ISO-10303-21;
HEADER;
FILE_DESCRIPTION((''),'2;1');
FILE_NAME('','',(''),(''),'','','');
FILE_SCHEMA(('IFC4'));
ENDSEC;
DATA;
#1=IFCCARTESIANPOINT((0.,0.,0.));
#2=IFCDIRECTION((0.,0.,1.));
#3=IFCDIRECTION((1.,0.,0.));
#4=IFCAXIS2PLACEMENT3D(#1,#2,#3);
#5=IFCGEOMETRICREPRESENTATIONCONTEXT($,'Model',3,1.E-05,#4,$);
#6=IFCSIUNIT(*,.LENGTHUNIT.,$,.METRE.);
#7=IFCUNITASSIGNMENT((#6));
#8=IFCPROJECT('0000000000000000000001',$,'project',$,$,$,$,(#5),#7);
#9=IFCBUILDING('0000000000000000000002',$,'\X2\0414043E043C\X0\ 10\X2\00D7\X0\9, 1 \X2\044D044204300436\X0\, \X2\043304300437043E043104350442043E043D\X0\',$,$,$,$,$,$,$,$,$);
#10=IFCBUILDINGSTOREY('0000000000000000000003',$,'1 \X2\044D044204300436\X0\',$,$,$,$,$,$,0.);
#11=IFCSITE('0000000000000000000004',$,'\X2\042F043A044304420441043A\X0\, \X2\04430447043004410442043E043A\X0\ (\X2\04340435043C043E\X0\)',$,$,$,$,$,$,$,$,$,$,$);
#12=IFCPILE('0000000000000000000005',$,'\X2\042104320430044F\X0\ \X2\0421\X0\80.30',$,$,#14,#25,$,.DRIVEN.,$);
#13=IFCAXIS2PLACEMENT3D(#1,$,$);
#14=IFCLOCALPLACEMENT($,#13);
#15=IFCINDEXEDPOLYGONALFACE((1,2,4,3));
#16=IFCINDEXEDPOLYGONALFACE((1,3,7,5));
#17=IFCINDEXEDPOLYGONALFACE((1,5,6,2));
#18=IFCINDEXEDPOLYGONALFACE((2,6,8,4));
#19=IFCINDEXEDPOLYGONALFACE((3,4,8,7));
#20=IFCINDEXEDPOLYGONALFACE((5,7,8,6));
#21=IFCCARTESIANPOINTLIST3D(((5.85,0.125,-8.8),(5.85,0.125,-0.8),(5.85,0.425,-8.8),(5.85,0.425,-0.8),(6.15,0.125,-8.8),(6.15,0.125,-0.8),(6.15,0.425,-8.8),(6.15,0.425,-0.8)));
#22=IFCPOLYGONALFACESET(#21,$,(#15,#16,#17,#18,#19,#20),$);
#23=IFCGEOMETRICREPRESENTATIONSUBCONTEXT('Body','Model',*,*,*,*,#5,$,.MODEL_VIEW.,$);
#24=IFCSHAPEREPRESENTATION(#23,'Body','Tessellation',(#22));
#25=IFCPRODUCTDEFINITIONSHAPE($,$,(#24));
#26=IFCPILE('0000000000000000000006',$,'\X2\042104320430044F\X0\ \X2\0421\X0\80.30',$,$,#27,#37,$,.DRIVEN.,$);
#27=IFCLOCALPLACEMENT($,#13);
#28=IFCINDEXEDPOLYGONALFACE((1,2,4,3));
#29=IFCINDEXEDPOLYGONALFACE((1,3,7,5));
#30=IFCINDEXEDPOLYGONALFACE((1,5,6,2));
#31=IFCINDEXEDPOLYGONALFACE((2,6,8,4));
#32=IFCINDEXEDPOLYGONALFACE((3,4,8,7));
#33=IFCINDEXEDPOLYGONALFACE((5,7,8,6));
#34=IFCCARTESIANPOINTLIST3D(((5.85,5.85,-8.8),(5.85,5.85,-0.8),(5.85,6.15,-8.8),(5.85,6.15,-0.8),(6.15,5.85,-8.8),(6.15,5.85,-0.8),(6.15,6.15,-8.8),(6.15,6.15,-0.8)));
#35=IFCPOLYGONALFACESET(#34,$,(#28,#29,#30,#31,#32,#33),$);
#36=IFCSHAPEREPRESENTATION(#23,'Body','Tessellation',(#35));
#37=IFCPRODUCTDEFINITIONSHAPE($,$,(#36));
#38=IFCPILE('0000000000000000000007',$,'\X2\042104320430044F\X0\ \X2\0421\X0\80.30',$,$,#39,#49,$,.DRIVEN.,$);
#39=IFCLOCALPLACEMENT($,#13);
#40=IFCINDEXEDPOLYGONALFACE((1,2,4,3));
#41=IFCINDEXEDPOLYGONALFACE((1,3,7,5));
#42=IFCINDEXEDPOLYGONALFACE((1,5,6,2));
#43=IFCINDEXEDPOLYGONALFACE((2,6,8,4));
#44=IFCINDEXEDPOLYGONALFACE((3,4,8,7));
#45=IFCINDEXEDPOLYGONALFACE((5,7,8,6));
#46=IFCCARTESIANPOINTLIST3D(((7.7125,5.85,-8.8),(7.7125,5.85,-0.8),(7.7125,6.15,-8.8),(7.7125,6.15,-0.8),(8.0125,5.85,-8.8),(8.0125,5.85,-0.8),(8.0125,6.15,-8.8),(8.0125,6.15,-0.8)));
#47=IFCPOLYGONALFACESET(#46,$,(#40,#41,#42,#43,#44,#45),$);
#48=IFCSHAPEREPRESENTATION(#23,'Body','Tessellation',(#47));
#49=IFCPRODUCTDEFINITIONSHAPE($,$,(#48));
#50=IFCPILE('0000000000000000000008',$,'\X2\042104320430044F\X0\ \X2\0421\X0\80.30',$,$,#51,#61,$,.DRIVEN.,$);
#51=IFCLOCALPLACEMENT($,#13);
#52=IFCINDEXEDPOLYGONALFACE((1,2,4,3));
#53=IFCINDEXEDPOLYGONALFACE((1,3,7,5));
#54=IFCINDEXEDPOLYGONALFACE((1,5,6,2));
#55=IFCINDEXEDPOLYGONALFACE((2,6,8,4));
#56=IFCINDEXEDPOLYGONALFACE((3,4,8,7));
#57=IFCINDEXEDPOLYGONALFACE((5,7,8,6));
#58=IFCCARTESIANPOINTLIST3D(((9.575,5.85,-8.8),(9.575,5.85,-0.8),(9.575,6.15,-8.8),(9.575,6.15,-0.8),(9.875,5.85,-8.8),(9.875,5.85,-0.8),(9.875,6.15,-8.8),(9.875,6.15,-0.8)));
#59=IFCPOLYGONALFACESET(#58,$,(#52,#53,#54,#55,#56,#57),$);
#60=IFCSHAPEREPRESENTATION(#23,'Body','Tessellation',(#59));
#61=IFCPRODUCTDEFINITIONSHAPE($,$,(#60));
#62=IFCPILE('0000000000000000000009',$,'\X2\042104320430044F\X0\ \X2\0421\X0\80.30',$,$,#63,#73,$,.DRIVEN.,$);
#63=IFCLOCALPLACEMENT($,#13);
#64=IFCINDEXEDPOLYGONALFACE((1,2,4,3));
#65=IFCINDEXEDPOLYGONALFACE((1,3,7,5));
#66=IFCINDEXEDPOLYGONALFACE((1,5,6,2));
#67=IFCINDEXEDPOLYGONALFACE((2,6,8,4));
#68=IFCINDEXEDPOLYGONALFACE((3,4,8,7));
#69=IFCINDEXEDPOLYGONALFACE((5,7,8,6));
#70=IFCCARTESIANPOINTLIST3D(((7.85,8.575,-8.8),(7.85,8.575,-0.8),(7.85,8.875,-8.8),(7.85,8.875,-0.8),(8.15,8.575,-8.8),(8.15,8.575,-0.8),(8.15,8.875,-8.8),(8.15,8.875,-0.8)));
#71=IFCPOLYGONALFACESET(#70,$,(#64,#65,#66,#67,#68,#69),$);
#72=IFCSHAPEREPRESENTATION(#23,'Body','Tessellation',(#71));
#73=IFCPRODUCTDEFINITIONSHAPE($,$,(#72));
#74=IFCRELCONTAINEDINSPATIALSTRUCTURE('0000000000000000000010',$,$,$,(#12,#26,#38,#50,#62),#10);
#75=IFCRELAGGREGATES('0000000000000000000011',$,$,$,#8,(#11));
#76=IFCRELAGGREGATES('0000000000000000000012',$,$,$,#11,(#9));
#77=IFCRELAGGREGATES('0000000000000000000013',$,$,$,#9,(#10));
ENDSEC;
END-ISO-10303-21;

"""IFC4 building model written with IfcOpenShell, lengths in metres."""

from ifc_helpers import new_model, si_unit, frame, origin_with_axes, place, context, subcontext, project, spatial, rectangle, extrude, element, save


model = new_model("IFC4")

# Units and contexts
model_context = context("Model", 3, precision=1e-05, world=origin_with_axes())
body_context = subcontext(model_context, "Body", "Model", "MODEL_VIEW")
ifc_project = project(units=[si_unit("LENGTHUNIT", "METRE")], contexts=[model_context])

# Site, building, storey
site = spatial("IfcSite", under=ifc_project, Name="Якутск, участок (демо)")
building = spatial("IfcBuilding", under=site, Name="Дом 10×9, 1 этаж, газобетон")
storey = spatial("IfcBuildingStorey", under=building, Name="1 этаж", Elevation=0.0)

# Piles
for number, where, z_axis, x_axis, name in (
    (1, (6.0, 0.275, -8.8), (0.0, 0.0, 1.0), (1.0, 0.0, 0.0), "Свая С80.30"),
    (2, (6.0, 6.0, -8.8), (0.0, 0.0, 1.0), (1.0, 0.0, 0.0), "Свая С80.30"),
    (3, (7.8625, 6.0, -8.8), (0.0, 0.0, 1.0), (1.0, 0.0, 0.0), "Свая С80.30"),
    (4, (9.725, 6.0, -8.8), (0.0, 0.0, 1.0), (1.0, 0.0, 0.0), "Свая С80.30"),
    (5, (8.0, 8.725, -8.8), (0.0, 0.0, 1.0), (1.0, 0.0, 0.0), "Свая С80.30"),
):
    element("IfcPile", number, at=place(None, frame(where, z_axis=z_axis, x_axis=x_axis)), inside=storey, Name=name, PredefinedType="DRIVEN", context=body_context, shape_type="SweptSolid", body=[
        extrude(rectangle(XDim=0.3, YDim=0.3), origin_with_axes(), (0.0, 0.0, 1.0), 8.0),
    ])

save(model, "model.ifc")
